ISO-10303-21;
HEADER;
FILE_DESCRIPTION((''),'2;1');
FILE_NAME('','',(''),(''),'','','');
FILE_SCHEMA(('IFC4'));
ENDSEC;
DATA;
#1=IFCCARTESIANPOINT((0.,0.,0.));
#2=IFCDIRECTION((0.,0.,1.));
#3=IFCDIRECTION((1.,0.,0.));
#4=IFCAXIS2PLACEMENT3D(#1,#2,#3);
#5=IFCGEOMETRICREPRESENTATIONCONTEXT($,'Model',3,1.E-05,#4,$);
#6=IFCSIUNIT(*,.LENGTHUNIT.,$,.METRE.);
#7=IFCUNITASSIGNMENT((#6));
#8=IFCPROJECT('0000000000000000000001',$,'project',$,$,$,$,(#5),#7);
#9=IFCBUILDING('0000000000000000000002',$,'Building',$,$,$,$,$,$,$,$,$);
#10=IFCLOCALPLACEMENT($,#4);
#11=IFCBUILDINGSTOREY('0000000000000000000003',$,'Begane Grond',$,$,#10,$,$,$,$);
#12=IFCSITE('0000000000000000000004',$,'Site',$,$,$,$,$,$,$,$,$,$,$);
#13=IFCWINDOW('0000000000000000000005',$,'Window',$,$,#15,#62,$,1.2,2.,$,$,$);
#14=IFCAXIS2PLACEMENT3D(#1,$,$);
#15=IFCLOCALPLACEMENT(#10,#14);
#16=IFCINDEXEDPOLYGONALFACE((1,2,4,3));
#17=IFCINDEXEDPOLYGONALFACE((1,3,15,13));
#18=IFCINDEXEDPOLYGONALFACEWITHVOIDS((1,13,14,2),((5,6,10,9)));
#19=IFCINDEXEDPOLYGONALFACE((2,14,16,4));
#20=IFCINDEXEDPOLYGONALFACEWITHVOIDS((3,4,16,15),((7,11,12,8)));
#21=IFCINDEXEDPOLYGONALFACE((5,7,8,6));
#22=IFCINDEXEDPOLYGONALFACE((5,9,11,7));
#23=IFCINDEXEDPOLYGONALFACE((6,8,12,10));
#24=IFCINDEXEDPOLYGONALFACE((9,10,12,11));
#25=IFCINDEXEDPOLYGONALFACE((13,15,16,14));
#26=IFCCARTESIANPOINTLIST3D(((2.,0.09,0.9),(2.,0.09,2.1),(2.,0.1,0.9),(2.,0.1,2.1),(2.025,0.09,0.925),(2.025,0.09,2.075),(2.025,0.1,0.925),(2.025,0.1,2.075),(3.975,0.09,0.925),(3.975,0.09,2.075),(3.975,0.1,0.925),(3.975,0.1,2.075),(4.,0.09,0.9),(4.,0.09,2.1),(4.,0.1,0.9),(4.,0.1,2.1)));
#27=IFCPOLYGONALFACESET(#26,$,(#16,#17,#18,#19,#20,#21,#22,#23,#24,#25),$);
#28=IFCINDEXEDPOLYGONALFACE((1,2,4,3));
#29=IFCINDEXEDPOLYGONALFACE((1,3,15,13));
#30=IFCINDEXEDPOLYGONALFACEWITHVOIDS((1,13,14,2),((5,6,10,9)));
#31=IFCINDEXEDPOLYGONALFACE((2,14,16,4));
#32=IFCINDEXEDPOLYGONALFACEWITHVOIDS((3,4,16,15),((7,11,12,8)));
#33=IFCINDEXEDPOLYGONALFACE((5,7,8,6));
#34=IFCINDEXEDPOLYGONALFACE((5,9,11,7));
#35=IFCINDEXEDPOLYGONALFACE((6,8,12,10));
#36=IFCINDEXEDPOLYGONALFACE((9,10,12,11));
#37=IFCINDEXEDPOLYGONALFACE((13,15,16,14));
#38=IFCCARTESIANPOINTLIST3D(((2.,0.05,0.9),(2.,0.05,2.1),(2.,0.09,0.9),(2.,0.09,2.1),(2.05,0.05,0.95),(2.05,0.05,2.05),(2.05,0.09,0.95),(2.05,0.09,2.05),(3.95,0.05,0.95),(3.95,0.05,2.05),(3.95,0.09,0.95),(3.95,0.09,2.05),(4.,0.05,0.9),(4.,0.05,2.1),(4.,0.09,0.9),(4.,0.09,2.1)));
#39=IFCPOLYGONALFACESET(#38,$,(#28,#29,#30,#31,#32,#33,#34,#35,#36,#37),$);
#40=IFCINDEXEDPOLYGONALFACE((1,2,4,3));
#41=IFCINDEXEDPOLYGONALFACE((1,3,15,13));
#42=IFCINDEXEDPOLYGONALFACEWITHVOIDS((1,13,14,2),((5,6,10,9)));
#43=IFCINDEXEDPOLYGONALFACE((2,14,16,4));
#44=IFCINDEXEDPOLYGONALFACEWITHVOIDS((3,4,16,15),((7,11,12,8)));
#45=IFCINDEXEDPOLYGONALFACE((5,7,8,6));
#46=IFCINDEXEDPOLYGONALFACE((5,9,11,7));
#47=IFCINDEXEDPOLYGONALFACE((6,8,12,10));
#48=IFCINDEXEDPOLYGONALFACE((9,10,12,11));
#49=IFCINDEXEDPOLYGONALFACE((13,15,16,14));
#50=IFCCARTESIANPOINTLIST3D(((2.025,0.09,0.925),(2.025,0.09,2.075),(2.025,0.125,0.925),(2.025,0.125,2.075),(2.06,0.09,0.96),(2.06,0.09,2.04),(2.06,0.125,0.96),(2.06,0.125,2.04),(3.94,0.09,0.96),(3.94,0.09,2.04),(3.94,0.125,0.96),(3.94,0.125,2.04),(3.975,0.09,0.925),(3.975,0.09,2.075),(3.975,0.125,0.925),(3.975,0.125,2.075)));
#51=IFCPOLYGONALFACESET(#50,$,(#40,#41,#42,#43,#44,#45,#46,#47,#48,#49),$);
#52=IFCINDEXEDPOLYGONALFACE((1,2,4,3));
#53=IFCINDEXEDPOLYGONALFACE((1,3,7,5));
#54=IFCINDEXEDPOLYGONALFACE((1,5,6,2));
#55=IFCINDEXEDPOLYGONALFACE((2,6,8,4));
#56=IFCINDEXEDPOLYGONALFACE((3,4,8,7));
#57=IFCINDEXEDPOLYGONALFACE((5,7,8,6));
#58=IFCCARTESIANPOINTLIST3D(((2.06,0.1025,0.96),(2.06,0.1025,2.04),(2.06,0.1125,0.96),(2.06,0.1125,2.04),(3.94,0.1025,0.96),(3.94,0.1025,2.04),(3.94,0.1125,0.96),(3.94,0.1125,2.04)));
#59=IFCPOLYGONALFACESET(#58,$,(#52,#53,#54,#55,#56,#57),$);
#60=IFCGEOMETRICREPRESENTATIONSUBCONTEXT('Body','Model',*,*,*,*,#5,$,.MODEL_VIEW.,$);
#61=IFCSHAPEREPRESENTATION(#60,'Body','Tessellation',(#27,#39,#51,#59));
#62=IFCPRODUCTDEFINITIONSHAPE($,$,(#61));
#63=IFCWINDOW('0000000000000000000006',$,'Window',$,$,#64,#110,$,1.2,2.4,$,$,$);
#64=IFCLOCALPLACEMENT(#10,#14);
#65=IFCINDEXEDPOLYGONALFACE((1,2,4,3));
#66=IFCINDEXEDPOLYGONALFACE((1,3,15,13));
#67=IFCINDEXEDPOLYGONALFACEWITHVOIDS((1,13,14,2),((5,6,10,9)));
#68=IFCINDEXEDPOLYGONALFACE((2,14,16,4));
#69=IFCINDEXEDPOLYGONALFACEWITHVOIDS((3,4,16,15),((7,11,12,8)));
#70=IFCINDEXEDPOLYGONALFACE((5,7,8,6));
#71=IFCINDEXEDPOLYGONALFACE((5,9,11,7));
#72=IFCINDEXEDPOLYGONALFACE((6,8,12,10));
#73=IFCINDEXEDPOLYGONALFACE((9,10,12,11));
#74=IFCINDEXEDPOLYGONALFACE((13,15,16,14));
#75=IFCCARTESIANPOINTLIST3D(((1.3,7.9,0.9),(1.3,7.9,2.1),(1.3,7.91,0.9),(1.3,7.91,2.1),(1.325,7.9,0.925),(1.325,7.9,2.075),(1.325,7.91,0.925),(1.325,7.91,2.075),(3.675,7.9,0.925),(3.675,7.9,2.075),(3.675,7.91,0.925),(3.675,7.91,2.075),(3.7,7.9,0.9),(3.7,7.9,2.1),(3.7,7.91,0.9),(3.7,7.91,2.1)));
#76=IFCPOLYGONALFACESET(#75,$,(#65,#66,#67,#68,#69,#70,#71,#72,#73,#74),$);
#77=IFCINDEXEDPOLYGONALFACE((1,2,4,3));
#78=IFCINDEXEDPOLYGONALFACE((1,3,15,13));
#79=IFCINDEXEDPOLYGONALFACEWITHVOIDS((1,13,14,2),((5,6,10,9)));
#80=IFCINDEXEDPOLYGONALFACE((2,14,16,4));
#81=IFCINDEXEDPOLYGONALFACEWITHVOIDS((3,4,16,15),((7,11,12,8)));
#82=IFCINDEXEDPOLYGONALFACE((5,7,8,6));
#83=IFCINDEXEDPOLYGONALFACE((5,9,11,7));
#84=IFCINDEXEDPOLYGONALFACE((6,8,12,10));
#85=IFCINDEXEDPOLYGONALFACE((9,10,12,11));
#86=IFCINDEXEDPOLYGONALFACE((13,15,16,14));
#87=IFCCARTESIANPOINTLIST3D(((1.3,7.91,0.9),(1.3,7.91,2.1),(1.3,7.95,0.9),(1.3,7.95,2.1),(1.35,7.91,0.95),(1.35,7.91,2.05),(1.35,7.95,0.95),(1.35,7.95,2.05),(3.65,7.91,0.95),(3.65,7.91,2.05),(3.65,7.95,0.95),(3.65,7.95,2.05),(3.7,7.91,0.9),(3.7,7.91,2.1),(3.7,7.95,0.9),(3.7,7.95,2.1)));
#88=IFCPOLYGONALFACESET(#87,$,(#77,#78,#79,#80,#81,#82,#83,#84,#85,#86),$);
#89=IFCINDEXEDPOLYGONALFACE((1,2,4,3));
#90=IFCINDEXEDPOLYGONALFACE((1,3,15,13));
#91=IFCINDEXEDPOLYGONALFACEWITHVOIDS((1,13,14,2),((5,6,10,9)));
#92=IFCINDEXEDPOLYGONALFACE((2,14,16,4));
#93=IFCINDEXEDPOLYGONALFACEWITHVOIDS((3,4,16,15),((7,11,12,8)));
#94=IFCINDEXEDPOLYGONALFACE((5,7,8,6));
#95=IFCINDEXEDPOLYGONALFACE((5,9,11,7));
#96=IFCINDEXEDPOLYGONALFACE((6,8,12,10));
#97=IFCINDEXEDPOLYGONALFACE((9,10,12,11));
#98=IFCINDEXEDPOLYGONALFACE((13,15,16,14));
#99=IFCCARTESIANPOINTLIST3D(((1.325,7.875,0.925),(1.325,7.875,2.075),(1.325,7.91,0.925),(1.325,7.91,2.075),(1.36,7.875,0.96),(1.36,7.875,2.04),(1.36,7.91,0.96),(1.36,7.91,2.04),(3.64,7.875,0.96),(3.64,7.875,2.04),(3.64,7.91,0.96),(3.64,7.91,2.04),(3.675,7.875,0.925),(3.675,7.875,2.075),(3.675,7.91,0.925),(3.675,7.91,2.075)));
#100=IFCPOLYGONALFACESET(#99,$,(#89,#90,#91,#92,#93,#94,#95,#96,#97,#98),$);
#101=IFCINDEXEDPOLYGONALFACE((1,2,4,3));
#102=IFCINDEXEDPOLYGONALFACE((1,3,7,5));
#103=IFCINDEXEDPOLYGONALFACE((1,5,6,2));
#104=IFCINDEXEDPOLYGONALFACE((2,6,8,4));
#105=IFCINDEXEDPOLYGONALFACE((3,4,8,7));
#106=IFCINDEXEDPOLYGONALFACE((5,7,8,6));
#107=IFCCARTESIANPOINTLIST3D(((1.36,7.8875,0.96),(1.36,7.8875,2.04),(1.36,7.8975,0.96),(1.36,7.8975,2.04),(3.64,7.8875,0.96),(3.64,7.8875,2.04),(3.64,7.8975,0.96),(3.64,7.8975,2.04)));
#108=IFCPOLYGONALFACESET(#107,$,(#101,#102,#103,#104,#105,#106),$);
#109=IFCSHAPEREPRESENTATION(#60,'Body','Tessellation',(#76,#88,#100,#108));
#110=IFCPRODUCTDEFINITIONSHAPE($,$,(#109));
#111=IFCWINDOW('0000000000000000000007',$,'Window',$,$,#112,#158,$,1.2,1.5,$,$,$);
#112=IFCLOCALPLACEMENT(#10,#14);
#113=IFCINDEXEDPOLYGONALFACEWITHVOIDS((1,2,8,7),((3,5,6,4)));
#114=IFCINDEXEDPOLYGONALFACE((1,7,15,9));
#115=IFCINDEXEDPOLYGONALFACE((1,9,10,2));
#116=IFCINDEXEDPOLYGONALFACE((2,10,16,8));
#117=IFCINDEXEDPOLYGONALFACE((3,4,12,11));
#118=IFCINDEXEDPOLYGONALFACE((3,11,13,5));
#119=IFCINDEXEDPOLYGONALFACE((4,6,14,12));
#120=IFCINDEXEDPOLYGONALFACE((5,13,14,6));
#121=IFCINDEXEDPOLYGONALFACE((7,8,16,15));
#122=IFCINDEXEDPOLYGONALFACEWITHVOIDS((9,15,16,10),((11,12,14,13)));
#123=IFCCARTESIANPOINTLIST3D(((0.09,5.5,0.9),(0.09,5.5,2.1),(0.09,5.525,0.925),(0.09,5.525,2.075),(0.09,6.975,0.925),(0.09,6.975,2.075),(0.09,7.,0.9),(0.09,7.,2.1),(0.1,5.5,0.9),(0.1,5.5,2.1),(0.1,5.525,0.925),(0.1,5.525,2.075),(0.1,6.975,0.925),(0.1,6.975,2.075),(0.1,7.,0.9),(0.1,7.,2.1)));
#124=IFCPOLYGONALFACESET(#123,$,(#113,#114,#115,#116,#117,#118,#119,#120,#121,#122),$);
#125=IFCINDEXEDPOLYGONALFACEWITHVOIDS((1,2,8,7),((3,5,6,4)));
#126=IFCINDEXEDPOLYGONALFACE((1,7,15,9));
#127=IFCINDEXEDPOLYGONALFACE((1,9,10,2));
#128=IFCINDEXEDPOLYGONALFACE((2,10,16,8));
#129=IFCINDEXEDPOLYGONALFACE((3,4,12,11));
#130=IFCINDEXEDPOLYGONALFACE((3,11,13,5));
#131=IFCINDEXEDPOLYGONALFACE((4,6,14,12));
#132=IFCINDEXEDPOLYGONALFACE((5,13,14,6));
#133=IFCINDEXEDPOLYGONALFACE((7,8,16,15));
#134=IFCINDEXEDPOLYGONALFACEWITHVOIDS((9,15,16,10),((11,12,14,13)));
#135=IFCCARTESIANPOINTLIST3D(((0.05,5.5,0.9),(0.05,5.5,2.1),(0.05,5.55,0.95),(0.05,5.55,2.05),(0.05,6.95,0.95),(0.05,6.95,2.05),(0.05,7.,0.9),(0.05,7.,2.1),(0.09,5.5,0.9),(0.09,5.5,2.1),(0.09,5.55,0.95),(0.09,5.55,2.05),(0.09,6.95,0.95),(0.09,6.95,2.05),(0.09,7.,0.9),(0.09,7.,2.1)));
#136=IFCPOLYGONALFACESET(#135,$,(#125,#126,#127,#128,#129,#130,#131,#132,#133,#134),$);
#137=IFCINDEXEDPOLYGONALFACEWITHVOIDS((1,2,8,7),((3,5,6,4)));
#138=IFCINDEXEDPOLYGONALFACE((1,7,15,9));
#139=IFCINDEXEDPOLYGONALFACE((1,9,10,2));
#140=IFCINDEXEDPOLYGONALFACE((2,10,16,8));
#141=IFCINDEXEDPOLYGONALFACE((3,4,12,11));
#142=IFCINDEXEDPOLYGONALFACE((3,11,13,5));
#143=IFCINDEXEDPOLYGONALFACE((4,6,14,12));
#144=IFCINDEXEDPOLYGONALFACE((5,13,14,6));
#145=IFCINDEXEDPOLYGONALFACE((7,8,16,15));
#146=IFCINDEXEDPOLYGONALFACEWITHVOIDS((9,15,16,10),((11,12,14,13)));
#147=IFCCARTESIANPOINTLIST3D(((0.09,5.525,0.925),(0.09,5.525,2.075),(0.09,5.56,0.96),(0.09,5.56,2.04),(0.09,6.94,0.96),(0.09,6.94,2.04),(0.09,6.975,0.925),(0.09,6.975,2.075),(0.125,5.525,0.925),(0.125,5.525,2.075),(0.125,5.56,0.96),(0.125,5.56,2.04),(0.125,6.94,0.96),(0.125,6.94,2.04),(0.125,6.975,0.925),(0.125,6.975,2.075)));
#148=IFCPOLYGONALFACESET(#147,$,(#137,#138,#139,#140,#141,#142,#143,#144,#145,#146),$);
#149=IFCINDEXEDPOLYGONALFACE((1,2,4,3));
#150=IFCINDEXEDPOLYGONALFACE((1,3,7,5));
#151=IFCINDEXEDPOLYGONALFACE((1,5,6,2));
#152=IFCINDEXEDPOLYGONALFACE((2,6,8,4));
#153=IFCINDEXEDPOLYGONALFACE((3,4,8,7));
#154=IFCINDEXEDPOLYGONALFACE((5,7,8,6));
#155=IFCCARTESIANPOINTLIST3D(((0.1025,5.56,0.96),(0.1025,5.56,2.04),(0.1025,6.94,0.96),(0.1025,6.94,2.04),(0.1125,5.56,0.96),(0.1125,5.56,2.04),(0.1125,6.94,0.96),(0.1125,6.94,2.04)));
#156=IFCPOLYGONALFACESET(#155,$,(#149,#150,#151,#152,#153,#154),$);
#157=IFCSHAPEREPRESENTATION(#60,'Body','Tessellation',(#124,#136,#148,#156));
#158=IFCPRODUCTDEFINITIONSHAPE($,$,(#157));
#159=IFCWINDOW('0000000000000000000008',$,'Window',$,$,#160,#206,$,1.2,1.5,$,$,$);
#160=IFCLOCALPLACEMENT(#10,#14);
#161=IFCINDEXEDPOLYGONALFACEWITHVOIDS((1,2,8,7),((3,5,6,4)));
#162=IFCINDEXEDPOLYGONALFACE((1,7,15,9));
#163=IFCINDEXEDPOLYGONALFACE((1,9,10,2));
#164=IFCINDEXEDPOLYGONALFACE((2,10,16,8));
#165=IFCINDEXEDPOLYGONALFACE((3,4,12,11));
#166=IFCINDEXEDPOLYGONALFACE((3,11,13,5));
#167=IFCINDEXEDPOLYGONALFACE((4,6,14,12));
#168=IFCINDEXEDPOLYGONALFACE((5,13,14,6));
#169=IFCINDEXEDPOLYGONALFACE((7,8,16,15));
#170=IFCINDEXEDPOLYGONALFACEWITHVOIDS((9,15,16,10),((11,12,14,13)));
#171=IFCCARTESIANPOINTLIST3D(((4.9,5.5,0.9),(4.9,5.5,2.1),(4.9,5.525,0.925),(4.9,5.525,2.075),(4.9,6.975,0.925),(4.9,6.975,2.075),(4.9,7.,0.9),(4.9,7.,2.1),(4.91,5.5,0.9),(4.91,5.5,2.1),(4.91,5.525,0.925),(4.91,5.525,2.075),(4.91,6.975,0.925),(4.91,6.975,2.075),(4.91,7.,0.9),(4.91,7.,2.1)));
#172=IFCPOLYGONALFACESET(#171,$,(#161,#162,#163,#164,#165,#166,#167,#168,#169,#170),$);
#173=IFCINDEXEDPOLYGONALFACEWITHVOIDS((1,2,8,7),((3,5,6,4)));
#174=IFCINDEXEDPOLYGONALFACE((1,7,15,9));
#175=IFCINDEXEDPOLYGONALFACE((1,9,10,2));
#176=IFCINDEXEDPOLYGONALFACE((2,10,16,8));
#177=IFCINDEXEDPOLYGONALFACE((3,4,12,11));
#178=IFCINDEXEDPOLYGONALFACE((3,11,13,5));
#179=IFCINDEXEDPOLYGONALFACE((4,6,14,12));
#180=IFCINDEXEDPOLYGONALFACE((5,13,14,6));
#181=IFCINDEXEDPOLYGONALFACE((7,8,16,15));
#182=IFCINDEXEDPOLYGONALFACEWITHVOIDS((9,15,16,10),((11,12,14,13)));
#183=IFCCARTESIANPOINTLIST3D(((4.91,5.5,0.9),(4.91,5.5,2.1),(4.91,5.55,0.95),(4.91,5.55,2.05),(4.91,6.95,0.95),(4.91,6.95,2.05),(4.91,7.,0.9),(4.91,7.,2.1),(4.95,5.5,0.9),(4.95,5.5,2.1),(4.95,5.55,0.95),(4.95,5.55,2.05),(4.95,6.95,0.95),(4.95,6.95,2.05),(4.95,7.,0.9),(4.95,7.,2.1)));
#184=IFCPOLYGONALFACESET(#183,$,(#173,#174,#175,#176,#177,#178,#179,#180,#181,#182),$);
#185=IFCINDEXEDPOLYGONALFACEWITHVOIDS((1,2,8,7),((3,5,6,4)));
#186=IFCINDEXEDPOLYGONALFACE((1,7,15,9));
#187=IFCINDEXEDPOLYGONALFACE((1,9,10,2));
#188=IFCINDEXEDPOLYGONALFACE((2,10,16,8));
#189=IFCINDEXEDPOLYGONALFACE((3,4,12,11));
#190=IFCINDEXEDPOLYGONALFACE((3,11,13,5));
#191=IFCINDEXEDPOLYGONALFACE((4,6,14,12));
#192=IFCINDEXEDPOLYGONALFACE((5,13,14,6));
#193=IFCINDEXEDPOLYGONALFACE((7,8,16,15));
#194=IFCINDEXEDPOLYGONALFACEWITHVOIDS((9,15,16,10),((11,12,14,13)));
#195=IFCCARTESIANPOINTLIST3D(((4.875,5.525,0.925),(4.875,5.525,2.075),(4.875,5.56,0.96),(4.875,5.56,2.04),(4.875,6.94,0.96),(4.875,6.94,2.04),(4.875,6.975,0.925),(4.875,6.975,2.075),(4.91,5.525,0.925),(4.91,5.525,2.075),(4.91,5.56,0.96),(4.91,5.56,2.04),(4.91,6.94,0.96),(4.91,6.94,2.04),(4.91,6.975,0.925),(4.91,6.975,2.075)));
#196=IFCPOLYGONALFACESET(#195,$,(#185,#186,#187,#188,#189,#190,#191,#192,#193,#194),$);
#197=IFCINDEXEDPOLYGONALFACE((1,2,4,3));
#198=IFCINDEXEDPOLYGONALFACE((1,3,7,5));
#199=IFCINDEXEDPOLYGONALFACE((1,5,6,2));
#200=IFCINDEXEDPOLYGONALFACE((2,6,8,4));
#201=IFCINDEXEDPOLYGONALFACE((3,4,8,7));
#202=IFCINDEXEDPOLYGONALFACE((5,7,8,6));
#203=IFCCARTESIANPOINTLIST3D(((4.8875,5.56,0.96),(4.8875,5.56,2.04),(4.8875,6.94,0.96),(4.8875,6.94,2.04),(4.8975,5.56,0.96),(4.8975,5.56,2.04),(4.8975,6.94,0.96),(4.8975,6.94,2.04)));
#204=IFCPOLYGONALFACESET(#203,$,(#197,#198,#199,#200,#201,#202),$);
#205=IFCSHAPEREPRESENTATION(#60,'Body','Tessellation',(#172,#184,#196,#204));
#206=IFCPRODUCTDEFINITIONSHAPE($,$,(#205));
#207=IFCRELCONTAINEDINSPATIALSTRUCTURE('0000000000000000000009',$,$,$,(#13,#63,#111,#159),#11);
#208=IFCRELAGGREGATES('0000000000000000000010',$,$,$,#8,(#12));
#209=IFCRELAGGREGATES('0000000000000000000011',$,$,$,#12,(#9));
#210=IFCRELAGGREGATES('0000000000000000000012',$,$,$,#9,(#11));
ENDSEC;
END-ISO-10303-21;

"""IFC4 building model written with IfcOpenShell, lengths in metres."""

from ifc_helpers import new_model, si_unit, frame, origin_with_axes, place, context, subcontext, project, spatial, line, indexed_curve, outline, extrude, element, save


model = new_model("IFC4")

# Units and contexts
model_context = context("Model", 3, precision=1e-05, world=origin_with_axes())
body_context = subcontext(model_context, "Body", "Model", "MODEL_VIEW")
ifc_project = project(units=[si_unit("LENGTHUNIT", "METRE")], contexts=[model_context])

# Site, building, storey
site = spatial("IfcSite", under=ifc_project, Name="Site")
building = spatial("IfcBuilding", under=site, Name="Building")
storey_placement = place(None, origin_with_axes())
storey = spatial("IfcBuildingStorey", under=building, at=storey_placement, Name="Begane Grond")

# Windows
window_1_placement = place(storey_placement, frame((2.0, 0.0, 0.9), z_axis=(0.0, 0.0, 1.0), x_axis=(1.0, 0.0, 0.0)))
element("IfcWindow", 1, at=window_1_placement, inside=storey, Name="Window", OverallHeight=1.2, OverallWidth=2.0, context=body_context, shape_type="SweptSolid", body=[
    extrude(outline(indexed_curve([(0.0, 0.0), (2.0, 0.0), (2.0, 1.2), (0.0, 1.2)], segments=[line(1, 2, 3, 4, 1)]), holes=[indexed_curve([(0.025, 0.025), (1.975, 0.025), (1.975, 1.175), (0.025, 1.175)], segments=[line(1, 2, 3, 4, 1)])]), frame((0.0, 0.09, 0.0), z_axis=(0.0, -1.0, 0.0), x_axis=(1.0, 0.0, 0.0)), (0.0, 0.0, -1.0), 0.01),
    extrude(outline(indexed_curve([(0.0, 0.0), (2.0, 0.0), (2.0, 1.2), (0.0, 1.2)], segments=[line(1, 2, 3, 4, 1)]), holes=[indexed_curve([(0.05, 0.05), (1.95, 0.05), (1.95, 1.15), (0.05, 1.15)], segments=[line(1, 2, 3, 4, 1)])]), frame((0.0, 0.05, 0.0), z_axis=(0.0, -1.0, 0.0), x_axis=(1.0, 0.0, 0.0)), (0.0, 0.0, -1.0), 0.04),
    extrude(outline(indexed_curve([(0.0, 0.0), (1.95, 0.0), (1.95, 1.15), (0.0, 1.15)], segments=[line(1, 2, 3, 4, 1)]), holes=[indexed_curve([(0.035, 0.035), (1.915, 0.035), (1.915, 1.115), (0.035, 1.115)], segments=[line(1, 2, 3, 4, 1)])]), frame((0.025, 0.09, 0.025), z_axis=(0.0, -1.0, 0.0), x_axis=(1.0, 0.0, 0.0)), (0.0, 0.0, -1.0), 0.035),
    extrude(outline(indexed_curve([(0.035, 0.035), (1.915, 0.035), (1.915, 1.115), (0.035, 1.115)], segments=[line(1, 2, 3, 4, 1)])), frame((0.025, 0.1025, 0.025), z_axis=(0.0, -1.0, 0.0), x_axis=(1.0, 0.0, 0.0)), (0.0, 0.0, -1.0), 0.01),
])
window_2_placement = place(storey_placement, frame((3.7, 8.0, 0.9), z_axis=(0.0, 0.0, 1.0), x_axis=(-1.0, 0.0, 0.0)))
element("IfcWindow", 2, at=window_2_placement, inside=storey, Name="Window", OverallHeight=1.2, OverallWidth=2.4, context=body_context, shape_type="SweptSolid", body=[
    extrude(outline(indexed_curve([(0.0, 0.0), (2.4, 0.0), (2.4, 1.2), (0.0, 1.2)], segments=[line(1, 2, 3, 4, 1)]), holes=[indexed_curve([(0.025, 0.025), (2.375, 0.025), (2.375, 1.175), (0.025, 1.175)], segments=[line(1, 2, 3, 4, 1)])]), frame((0.0, 0.09, 0.0), z_axis=(0.0, -1.0, 0.0), x_axis=(1.0, 0.0, 0.0)), (0.0, 0.0, -1.0), 0.01),
    extrude(outline(indexed_curve([(0.0, 0.0), (2.4, 0.0), (2.4, 1.2), (0.0, 1.2)], segments=[line(1, 2, 3, 4, 1)]), holes=[indexed_curve([(0.05, 0.05), (2.35, 0.05), (2.35, 1.15), (0.05, 1.15)], segments=[line(1, 2, 3, 4, 1)])]), frame((0.0, 0.05, 0.0), z_axis=(0.0, -1.0, 0.0), x_axis=(1.0, 0.0, 0.0)), (0.0, 0.0, -1.0), 0.04),
    extrude(outline(indexed_curve([(0.0, 0.0), (2.35, 0.0), (2.35, 1.15), (0.0, 1.15)], segments=[line(1, 2, 3, 4, 1)]), holes=[indexed_curve([(0.035, 0.035), (2.315, 0.035), (2.315, 1.115), (0.035, 1.115)], segments=[line(1, 2, 3, 4, 1)])]), frame((0.025, 0.09, 0.025), z_axis=(0.0, -1.0, 0.0), x_axis=(1.0, 0.0, 0.0)), (0.0, 0.0, -1.0), 0.035),
    extrude(outline(indexed_curve([(0.035, 0.035), (2.315, 0.035), (2.315, 1.115), (0.035, 1.115)], segments=[line(1, 2, 3, 4, 1)])), frame((0.025, 0.1025, 0.025), z_axis=(0.0, -1.0, 0.0), x_axis=(1.0, 0.0, 0.0)), (0.0, 0.0, -1.0), 0.01),
])
for number, where, z_axis, x_axis, name in (
    (3, (0.0, 7.0, 0.9), (0.0, 0.0, 1.0), (0.0, -1.0, 0.0), "Window"),
    (4, (5.0, 5.5, 0.9), (0.0, 0.0, 1.0), (0.0, 1.0, 0.0), "Window"),
):
    element("IfcWindow", number, at=place(storey_placement, frame(where, z_axis=z_axis, x_axis=x_axis)), inside=storey, Name=name, OverallHeight=1.2, OverallWidth=1.5, context=body_context, shape_type="SweptSolid", body=[
        extrude(outline(indexed_curve([(0.0, 0.0), (1.5, 0.0), (1.5, 1.2), (0.0, 1.2)], segments=[line(1, 2, 3, 4, 1)]), holes=[indexed_curve([(0.025, 0.025), (1.475, 0.025), (1.475, 1.175), (0.025, 1.175)], segments=[line(1, 2, 3, 4, 1)])]), frame((0.0, 0.09, 0.0), z_axis=(0.0, -1.0, 0.0), x_axis=(1.0, 0.0, 0.0)), (0.0, 0.0, -1.0), 0.01),
        extrude(outline(indexed_curve([(0.0, 0.0), (1.5, 0.0), (1.5, 1.2), (0.0, 1.2)], segments=[line(1, 2, 3, 4, 1)]), holes=[indexed_curve([(0.05, 0.05), (1.45, 0.05), (1.45, 1.15), (0.05, 1.15)], segments=[line(1, 2, 3, 4, 1)])]), frame((0.0, 0.05, 0.0), z_axis=(0.0, -1.0, 0.0), x_axis=(1.0, 0.0, 0.0)), (0.0, 0.0, -1.0), 0.04),
        extrude(outline(indexed_curve([(0.0, 0.0), (1.45, 0.0), (1.45, 1.15), (0.0, 1.15)], segments=[line(1, 2, 3, 4, 1)]), holes=[indexed_curve([(0.035, 0.035), (1.415, 0.035), (1.415, 1.115), (0.035, 1.115)], segments=[line(1, 2, 3, 4, 1)])]), frame((0.025, 0.09, 0.025), z_axis=(0.0, -1.0, 0.0), x_axis=(1.0, 0.0, 0.0)), (0.0, 0.0, -1.0), 0.035),
        extrude(outline(indexed_curve([(0.035, 0.035), (1.415, 0.035), (1.415, 1.115), (0.035, 1.115)], segments=[line(1, 2, 3, 4, 1)])), frame((0.025, 0.1025, 0.025), z_axis=(0.0, -1.0, 0.0), x_axis=(1.0, 0.0, 0.0)), (0.0, 0.0, -1.0), 0.01),
    ])

save(model, "model.ifc")
